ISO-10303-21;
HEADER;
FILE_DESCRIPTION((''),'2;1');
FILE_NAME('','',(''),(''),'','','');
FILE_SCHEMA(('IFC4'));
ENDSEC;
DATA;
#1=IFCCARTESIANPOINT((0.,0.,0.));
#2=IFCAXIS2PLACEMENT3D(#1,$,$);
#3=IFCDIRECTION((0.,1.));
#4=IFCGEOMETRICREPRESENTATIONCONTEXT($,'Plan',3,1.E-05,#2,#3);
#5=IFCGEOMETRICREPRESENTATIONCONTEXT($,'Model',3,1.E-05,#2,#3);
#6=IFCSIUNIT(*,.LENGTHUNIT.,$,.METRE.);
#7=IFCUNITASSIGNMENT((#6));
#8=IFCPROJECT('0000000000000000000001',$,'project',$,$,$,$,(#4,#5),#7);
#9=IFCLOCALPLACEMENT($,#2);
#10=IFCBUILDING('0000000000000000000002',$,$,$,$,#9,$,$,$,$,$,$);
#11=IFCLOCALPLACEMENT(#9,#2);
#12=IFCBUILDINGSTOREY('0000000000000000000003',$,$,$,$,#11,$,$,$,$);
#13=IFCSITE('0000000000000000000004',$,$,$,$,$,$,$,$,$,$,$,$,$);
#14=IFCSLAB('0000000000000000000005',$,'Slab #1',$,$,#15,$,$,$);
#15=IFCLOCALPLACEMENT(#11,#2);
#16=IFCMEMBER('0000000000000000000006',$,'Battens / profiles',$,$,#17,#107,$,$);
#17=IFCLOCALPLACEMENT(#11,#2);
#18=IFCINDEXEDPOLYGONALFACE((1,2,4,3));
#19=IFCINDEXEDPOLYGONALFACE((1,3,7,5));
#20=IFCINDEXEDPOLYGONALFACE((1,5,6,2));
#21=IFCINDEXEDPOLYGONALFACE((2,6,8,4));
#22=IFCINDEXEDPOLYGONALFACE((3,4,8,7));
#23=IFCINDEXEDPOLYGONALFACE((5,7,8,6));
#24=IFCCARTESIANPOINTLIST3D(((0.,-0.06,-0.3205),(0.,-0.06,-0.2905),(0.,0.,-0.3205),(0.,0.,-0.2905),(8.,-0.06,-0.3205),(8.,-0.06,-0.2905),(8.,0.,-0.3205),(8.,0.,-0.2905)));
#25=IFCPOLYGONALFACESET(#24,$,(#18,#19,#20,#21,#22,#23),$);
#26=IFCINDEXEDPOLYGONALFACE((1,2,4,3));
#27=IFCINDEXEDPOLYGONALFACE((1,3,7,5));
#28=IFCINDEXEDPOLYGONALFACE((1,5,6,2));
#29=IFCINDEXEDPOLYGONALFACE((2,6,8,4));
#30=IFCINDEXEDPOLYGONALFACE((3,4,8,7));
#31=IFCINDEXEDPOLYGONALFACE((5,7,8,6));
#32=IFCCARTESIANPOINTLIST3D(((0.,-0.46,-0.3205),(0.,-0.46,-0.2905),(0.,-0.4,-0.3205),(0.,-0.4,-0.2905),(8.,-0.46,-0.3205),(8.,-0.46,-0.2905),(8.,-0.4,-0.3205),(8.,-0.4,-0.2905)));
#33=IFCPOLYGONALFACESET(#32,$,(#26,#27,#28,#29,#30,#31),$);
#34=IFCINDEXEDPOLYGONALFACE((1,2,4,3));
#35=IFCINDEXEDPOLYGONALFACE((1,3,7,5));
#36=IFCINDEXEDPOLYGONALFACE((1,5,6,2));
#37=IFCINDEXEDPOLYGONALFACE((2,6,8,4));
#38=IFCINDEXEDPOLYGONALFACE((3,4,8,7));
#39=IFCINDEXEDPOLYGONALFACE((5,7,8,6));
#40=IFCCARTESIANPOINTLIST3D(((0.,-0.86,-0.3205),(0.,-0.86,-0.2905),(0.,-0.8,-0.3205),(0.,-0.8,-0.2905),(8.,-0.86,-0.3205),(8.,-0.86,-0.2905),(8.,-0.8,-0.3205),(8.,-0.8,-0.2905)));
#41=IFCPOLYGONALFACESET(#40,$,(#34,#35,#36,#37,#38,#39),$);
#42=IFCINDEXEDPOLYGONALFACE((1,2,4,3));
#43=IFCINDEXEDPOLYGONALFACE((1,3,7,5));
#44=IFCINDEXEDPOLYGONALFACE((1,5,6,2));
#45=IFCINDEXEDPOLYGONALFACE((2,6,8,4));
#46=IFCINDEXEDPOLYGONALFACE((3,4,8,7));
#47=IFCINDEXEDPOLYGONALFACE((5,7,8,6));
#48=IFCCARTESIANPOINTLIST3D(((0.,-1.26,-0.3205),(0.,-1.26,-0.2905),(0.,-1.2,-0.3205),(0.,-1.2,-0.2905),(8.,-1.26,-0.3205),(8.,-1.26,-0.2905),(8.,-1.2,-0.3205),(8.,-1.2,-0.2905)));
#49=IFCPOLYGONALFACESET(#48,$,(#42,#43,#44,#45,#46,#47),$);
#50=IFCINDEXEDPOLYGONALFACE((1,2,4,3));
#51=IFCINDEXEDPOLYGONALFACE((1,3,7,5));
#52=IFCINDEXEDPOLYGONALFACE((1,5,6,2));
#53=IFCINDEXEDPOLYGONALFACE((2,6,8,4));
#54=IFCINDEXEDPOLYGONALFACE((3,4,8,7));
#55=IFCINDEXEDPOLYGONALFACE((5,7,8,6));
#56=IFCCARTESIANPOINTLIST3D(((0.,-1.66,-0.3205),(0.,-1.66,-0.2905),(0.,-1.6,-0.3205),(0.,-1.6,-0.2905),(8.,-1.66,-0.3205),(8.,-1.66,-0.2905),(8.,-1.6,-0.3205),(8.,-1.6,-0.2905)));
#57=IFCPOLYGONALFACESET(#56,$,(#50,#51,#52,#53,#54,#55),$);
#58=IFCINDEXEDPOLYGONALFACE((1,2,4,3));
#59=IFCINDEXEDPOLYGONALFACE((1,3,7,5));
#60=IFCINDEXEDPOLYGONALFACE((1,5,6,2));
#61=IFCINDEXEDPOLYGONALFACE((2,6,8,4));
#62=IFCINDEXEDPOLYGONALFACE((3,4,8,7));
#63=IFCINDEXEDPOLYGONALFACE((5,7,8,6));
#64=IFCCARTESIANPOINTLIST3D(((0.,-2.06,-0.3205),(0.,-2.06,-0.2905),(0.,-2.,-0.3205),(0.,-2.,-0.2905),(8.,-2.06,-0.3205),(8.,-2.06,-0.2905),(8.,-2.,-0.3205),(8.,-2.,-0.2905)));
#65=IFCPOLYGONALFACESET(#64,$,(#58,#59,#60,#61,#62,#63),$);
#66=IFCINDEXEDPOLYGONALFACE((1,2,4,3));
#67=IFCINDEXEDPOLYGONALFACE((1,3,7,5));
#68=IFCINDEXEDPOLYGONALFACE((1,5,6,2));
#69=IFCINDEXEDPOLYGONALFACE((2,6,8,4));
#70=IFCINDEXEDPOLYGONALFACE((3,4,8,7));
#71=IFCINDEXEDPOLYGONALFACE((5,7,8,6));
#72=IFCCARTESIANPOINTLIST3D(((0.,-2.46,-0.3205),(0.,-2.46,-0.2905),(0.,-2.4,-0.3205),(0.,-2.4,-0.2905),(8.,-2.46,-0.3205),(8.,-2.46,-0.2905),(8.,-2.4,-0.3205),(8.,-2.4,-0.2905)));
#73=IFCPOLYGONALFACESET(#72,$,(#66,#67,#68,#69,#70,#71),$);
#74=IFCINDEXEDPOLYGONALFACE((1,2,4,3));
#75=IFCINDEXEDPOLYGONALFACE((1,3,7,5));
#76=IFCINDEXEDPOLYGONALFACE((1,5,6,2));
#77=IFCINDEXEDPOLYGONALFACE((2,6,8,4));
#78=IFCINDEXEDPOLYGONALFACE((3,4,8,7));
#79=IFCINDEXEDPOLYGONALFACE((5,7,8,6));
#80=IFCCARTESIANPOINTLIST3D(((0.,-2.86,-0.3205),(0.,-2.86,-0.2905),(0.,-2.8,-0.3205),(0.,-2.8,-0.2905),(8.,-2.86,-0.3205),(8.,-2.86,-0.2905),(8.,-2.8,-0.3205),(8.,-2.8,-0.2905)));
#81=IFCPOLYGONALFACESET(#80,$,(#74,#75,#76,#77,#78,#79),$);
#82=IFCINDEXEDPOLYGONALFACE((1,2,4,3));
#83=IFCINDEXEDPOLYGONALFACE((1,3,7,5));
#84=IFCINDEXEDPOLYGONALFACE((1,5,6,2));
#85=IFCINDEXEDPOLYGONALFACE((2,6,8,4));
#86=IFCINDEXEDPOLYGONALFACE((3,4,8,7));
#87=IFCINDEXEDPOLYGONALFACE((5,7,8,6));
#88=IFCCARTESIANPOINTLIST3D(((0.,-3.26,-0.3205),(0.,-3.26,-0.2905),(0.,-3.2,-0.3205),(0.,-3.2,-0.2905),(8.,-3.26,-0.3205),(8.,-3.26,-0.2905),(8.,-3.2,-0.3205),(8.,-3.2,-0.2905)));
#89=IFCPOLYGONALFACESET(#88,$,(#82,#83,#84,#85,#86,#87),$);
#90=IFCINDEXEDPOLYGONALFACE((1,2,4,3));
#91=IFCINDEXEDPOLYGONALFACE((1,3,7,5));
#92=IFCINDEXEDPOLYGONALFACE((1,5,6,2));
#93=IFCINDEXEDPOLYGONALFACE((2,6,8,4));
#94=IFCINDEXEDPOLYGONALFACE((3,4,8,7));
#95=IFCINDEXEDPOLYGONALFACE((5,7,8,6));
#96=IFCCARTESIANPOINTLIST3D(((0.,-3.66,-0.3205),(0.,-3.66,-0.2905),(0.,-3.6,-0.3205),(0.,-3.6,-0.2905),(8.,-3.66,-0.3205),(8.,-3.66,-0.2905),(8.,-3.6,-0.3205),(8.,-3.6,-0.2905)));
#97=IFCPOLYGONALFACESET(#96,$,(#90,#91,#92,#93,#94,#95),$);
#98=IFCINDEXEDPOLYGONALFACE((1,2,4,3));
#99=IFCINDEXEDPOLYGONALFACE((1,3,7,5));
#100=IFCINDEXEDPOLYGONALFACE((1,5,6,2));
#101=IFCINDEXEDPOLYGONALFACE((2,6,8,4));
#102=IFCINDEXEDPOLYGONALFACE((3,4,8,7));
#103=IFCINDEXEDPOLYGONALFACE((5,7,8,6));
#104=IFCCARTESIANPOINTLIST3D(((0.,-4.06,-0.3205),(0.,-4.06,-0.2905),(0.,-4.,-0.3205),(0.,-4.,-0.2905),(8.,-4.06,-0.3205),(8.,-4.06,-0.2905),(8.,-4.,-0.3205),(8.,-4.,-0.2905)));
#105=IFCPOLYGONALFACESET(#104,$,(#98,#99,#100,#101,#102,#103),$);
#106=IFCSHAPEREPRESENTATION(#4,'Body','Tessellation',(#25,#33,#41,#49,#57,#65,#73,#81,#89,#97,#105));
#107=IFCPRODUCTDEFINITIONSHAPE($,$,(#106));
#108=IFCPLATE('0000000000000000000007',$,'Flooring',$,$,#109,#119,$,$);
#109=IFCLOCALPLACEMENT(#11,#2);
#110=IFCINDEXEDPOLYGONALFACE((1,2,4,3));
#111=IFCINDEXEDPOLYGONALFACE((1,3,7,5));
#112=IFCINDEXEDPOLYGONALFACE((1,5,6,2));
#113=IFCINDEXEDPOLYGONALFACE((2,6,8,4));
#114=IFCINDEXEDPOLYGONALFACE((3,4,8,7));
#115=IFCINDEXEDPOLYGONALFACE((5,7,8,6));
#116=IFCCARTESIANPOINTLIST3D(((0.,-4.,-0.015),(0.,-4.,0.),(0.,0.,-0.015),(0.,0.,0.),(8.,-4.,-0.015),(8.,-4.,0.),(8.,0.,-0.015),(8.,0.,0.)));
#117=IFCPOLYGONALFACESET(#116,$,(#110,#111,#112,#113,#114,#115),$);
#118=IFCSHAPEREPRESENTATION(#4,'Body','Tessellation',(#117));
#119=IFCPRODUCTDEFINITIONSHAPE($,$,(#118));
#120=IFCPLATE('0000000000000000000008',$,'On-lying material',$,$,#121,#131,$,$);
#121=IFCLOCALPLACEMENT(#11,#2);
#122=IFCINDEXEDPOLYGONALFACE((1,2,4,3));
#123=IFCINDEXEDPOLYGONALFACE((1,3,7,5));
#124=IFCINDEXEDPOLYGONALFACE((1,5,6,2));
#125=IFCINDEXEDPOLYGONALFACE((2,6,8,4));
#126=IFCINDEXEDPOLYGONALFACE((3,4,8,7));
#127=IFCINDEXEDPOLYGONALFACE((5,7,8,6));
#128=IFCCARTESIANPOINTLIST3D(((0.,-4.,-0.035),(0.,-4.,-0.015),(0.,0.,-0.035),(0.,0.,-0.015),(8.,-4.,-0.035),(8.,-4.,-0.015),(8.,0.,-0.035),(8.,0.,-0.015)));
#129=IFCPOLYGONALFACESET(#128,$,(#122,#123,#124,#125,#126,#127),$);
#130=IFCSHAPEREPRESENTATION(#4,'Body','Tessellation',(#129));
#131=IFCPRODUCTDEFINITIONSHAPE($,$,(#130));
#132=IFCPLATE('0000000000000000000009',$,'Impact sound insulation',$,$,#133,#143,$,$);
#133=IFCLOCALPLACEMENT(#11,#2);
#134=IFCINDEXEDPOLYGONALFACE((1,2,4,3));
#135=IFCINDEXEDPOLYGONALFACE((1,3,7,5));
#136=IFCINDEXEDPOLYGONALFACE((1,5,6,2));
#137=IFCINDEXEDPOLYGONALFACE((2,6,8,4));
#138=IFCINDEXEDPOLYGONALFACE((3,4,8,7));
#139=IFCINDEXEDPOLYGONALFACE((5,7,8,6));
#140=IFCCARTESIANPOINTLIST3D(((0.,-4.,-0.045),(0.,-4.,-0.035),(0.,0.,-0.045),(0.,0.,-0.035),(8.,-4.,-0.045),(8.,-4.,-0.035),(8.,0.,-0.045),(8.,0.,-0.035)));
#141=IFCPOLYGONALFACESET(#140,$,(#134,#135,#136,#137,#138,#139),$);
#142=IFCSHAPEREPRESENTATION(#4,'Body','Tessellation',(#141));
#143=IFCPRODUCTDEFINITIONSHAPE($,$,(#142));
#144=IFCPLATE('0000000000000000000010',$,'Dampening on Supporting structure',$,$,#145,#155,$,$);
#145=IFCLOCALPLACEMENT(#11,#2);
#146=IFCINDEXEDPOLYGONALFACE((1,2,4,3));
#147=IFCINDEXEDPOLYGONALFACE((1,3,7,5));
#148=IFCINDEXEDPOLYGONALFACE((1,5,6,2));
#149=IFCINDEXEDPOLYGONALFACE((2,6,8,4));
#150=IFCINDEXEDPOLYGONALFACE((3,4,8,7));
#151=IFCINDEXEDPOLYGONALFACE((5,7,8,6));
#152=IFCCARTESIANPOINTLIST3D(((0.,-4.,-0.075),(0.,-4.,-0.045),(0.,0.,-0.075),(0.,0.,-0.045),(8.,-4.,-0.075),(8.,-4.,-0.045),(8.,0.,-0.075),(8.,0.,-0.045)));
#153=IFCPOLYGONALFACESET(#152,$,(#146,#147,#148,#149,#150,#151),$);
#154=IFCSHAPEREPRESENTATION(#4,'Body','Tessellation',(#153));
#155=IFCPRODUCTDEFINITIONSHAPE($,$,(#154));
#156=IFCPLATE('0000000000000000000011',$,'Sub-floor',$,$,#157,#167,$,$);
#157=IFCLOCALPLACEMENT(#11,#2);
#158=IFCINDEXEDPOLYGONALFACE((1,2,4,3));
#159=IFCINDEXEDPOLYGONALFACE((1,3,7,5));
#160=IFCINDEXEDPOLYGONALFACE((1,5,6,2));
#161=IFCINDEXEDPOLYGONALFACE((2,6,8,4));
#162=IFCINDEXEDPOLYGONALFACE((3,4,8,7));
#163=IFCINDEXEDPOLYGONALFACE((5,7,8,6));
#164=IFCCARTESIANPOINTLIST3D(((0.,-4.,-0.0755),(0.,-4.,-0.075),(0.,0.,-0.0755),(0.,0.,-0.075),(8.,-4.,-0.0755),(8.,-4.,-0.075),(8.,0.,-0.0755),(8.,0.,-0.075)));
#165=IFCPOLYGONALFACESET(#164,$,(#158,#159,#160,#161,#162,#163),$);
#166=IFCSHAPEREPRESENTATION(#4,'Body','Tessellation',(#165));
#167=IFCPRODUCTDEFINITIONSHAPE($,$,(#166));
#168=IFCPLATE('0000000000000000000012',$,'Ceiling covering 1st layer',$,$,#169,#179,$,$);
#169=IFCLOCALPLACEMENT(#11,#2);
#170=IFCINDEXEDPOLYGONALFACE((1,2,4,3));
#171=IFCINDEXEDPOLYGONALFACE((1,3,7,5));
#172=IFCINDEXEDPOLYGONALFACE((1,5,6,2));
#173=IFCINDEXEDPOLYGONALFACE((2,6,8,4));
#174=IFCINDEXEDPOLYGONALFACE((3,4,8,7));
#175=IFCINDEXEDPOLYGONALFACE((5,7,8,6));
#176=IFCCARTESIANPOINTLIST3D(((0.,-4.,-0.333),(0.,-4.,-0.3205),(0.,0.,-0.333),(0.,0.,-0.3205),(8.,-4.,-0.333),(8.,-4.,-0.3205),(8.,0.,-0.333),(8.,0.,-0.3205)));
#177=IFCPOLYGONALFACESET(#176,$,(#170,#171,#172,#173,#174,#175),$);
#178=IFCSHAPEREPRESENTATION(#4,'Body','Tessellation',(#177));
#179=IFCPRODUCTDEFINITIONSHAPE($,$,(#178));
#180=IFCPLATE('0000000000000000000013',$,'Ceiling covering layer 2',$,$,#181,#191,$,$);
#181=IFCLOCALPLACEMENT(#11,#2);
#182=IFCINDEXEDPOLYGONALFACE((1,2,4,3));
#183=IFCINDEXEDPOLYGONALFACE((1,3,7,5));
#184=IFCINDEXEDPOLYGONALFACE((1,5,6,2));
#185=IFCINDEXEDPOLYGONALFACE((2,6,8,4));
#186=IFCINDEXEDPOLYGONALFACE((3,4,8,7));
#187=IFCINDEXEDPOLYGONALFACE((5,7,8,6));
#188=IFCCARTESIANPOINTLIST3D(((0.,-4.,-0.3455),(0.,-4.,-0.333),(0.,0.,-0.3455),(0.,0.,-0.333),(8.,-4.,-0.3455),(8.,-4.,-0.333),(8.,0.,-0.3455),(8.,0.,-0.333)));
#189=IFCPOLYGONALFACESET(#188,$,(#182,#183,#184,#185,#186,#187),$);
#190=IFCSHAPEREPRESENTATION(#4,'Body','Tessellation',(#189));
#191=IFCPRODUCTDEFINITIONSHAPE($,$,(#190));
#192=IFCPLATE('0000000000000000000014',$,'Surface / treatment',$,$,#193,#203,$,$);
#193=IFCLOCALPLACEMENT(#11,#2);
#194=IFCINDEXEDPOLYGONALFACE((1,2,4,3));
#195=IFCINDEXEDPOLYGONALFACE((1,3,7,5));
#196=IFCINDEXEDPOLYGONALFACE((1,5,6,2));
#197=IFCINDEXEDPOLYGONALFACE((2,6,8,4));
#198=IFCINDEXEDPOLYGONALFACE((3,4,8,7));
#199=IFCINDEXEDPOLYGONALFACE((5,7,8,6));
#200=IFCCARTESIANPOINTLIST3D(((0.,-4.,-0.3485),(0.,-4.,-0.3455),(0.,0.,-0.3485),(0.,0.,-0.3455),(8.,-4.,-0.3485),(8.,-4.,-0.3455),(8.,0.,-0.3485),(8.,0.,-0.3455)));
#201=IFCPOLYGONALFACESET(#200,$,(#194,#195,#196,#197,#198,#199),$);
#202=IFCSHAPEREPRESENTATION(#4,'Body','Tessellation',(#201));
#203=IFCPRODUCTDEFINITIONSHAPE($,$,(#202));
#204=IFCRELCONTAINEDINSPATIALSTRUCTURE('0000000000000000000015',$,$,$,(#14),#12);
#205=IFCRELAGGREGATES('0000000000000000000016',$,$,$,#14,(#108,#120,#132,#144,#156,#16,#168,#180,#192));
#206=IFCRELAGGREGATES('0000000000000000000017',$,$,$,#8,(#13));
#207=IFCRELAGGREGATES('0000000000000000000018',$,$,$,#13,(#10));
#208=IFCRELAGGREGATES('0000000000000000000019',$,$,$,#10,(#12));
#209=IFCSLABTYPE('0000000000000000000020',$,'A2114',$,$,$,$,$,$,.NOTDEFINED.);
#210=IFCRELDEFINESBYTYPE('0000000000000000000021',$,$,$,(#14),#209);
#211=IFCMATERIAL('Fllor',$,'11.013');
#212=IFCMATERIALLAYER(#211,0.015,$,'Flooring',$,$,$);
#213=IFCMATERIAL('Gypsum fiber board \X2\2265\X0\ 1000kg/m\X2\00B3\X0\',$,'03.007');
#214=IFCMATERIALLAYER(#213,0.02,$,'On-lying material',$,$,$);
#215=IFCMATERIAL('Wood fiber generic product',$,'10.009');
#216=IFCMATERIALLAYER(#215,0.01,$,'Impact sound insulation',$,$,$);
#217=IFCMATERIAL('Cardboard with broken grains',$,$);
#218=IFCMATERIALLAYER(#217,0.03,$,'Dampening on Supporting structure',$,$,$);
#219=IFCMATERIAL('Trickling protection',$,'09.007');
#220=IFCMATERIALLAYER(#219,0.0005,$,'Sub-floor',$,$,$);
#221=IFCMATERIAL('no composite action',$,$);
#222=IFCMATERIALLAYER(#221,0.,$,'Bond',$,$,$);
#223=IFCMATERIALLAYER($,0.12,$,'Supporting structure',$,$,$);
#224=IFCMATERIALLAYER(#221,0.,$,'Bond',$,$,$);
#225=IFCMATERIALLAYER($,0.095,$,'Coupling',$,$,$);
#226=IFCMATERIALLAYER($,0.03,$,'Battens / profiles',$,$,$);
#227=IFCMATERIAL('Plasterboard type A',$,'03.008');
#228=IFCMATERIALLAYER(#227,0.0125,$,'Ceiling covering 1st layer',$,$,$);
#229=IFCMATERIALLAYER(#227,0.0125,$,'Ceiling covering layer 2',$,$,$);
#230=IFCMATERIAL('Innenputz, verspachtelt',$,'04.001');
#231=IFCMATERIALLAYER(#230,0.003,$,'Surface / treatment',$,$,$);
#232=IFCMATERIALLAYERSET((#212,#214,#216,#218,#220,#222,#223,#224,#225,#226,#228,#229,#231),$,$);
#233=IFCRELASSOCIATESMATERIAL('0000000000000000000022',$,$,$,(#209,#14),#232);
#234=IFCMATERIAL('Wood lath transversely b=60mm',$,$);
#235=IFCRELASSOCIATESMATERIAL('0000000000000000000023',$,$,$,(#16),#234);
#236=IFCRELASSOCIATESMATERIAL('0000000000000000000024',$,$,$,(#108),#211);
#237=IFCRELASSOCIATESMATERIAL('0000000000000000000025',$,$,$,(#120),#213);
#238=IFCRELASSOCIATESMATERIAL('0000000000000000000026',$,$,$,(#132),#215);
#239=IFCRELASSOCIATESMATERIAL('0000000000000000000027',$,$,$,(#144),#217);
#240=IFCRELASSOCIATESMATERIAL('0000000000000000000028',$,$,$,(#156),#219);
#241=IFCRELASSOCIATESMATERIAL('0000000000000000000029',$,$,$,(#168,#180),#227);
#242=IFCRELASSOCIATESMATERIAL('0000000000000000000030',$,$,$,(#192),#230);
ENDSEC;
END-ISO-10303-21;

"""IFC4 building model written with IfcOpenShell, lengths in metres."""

from ifc_helpers import new_model, si_unit, direction, frame, frame_2d, origin, origin_with_axes, place, context, project, spatial, rectangle, extrude, material, layer, layer_set, type_object, element, aggregate, save


model = new_model("IFC4")

# Units and contexts
plan_context = context("Plan", 3, precision=1e-05, world=origin(), true_north=direction((0.0, 1.0)))
model_context = context("Model", 3, precision=1e-05, world=origin(), true_north=direction((0.0, 1.0)))
ifc_project = project(units=[si_unit("LENGTHUNIT", "METRE")], contexts=[plan_context, model_context])

# Site, building, storey
site = spatial("IfcSite", under=ifc_project)
building_placement = place(None, origin())
building = spatial("IfcBuilding", under=site, at=building_placement)
storey_placement = place(building_placement, origin())
storey = spatial("IfcBuildingStorey", under=building, at=storey_placement)

# Slab, member, plates
ifc_material_1 = material(Name="Fllor", Category="11.013")
ifc_layer_1 = layer(ifc_material_1, 0.015, Name="Flooring")
ifc_material_2 = material(Name="Gypsum fiber board ≥ 1000kg/m³", Category="03.007")
ifc_layer_2 = layer(ifc_material_2, 0.02, Name="On-lying material")
ifc_material_3 = material(Name="Wood fiber generic product", Category="10.009")
ifc_layer_3 = layer(ifc_material_3, 0.01, Name="Impact sound insulation")
ifc_material_4 = material(Name="Cardboard with broken grains")
ifc_layer_4 = layer(ifc_material_4, 0.03, Name="Dampening on Supporting structure")
ifc_material_5 = material(Name="Trickling protection", Category="09.007")
ifc_layer_5 = layer(ifc_material_5, 0.0005, Name="Sub-floor")
ifc_material_6 = material(Name="no composite action")
ifc_layer_6 = layer(ifc_material_6, 0.0, Name="Bond")
ifc_layer_7 = layer(None, 0.12, Name="Supporting structure")
ifc_layer_8 = layer(ifc_material_6, 0.0, Name="Bond")
ifc_layer_9 = layer(None, 0.095, Name="Coupling")
ifc_layer_10 = layer(None, 0.03, Name="Battens / profiles")
ifc_material_7 = material(Name="Plasterboard type A", Category="03.008")
ifc_layer_11 = layer(ifc_material_7, 0.0125, Name="Ceiling covering 1st layer")
ifc_layer_12 = layer(ifc_material_7, 0.0125, Name="Ceiling covering layer 2")
ifc_material_8 = material(Name="Innenputz, verspachtelt", Category="04.001")
ifc_layer_13 = layer(ifc_material_8, 0.003, Name="Surface / treatment")
ifc_layer_set = layer_set([ifc_layer_1, ifc_layer_2, ifc_layer_3, ifc_layer_4, ifc_layer_5, ifc_layer_6, ifc_layer_7, ifc_layer_8, ifc_layer_9, ifc_layer_10, ifc_layer_11, ifc_layer_12, ifc_layer_13])
slab_type = type_object("IfcSlabType", Name="A2114", PredefinedType="NOTDEFINED", material=ifc_layer_set)
slab_placement = place(None, frame((0.0, 0.0, 0.0), z_axis=(0.0, 0.0, -1.0), x_axis=(1.0, 0.0, 0.0)))
slab = element("IfcSlab", 1, at=slab_placement, inside=storey, type_object=slab_type, material=ifc_layer_set, Name="Slab #1")
ifc_material_9 = material(Name="Wood lath transversely b=60mm")
member_1_placement = place(slab_placement, origin())
member_1 = element("IfcMember", 2, at=member_1_placement, material=ifc_material_9, Name="Battens / profiles", context=plan_context, shape_type="SweptSolid", body=[
    extrude(rectangle(XDim=0.06, YDim=0.03, at=frame_2d((0.03, 0.015), x_axis=(1.0, 0.0))), frame((0.0, 0.0, 0.2905), z_axis=(1.0, 0.0, 0.0), x_axis=(0.0, 1.0, 0.0)), (0.0, 0.0, 1.0), 8.0),
    extrude(rectangle(XDim=0.06, YDim=0.03, at=frame_2d((0.03, 0.015), x_axis=(1.0, 0.0))), frame((0.0, 0.4, 0.2905), z_axis=(1.0, 0.0, 0.0), x_axis=(0.0, 1.0, 0.0)), (0.0, 0.0, 1.0), 8.0),
    extrude(rectangle(XDim=0.06, YDim=0.03, at=frame_2d((0.03, 0.015), x_axis=(1.0, 0.0))), frame((0.0, 0.8, 0.2905), z_axis=(1.0, 0.0, 0.0), x_axis=(0.0, 1.0, 0.0)), (0.0, 0.0, 1.0), 8.0),
    extrude(rectangle(XDim=0.06, YDim=0.03, at=frame_2d((0.03, 0.015), x_axis=(1.0, 0.0))), frame((0.0, 1.2, 0.2905), z_axis=(1.0, 0.0, 0.0), x_axis=(0.0, 1.0, 0.0)), (0.0, 0.0, 1.0), 8.0),
    extrude(rectangle(XDim=0.06, YDim=0.03, at=frame_2d((0.03, 0.015), x_axis=(1.0, 0.0))), frame((0.0, 1.6, 0.2905), z_axis=(1.0, 0.0, 0.0), x_axis=(0.0, 1.0, 0.0)), (0.0, 0.0, 1.0), 8.0),
    extrude(rectangle(XDim=0.06, YDim=0.03, at=frame_2d((0.03, 0.015), x_axis=(1.0, 0.0))), frame((0.0, 2.0, 0.2905), z_axis=(1.0, 0.0, 0.0), x_axis=(0.0, 1.0, 0.0)), (0.0, 0.0, 1.0), 8.0),
    extrude(rectangle(XDim=0.06, YDim=0.03, at=frame_2d((0.03, 0.015), x_axis=(1.0, 0.0))), frame((0.0, 2.4, 0.2905), z_axis=(1.0, 0.0, 0.0), x_axis=(0.0, 1.0, 0.0)), (0.0, 0.0, 1.0), 8.0),
    extrude(rectangle(XDim=0.06, YDim=0.03, at=frame_2d((0.03, 0.015), x_axis=(1.0, 0.0))), frame((0.0, 2.8, 0.2905), z_axis=(1.0, 0.0, 0.0), x_axis=(0.0, 1.0, 0.0)), (0.0, 0.0, 1.0), 8.0),
    extrude(rectangle(XDim=0.06, YDim=0.03, at=frame_2d((0.03, 0.015), x_axis=(1.0, 0.0))), frame((0.0, 3.2, 0.2905), z_axis=(1.0, 0.0, 0.0), x_axis=(0.0, 1.0, 0.0)), (0.0, 0.0, 1.0), 8.0),
    extrude(rectangle(XDim=0.06, YDim=0.03, at=frame_2d((0.03, 0.015), x_axis=(1.0, 0.0))), frame((0.0, 3.6, 0.2905), z_axis=(1.0, 0.0, 0.0), x_axis=(0.0, 1.0, 0.0)), (0.0, 0.0, 1.0), 8.0),
    extrude(rectangle(XDim=0.06, YDim=0.03, at=frame_2d((0.03, 0.015), x_axis=(1.0, 0.0))), frame((0.0, 4.0, 0.2905), z_axis=(1.0, 0.0, 0.0), x_axis=(0.0, 1.0, 0.0)), (0.0, 0.0, 1.0), 8.0),
])
plate_1_placement = place(slab_placement, origin())
plate_1 = element("IfcPlate", 3, at=plate_1_placement, material=ifc_material_1, Name="Flooring", context=plan_context, shape_type="SweptSolid", body=[
    extrude(rectangle(XDim=8.0, YDim=4.0, at=frame_2d((4.0, 2.0), x_axis=(1.0, 0.0))), origin_with_axes(), (0.0, 0.0, 1.0), 0.015),
])
plate_2_placement = place(slab_placement, origin())
plate_2 = element("IfcPlate", 4, at=plate_2_placement, material=ifc_material_2, Name="On-lying material", context=plan_context, shape_type="SweptSolid", body=[
    extrude(rectangle(XDim=8.0, YDim=4.0, at=frame_2d((4.0, 2.0), x_axis=(1.0, 0.0))), frame((0.0, 0.0, 0.015), z_axis=(0.0, 0.0, 1.0), x_axis=(1.0, 0.0, 0.0)), (0.0, 0.0, 1.0), 0.02),
])
plate_3_placement = place(slab_placement, origin())
plate_3 = element("IfcPlate", 5, at=plate_3_placement, material=ifc_material_3, Name="Impact sound insulation", context=plan_context, shape_type="SweptSolid", body=[
    extrude(rectangle(XDim=8.0, YDim=4.0, at=frame_2d((4.0, 2.0), x_axis=(1.0, 0.0))), frame((0.0, 0.0, 0.035), z_axis=(0.0, 0.0, 1.0), x_axis=(1.0, 0.0, 0.0)), (0.0, 0.0, 1.0), 0.01),
])
plate_4_placement = place(slab_placement, origin())
plate_4 = element("IfcPlate", 6, at=plate_4_placement, material=ifc_material_4, Name="Dampening on Supporting structure", context=plan_context, shape_type="SweptSolid", body=[
    extrude(rectangle(XDim=8.0, YDim=4.0, at=frame_2d((4.0, 2.0), x_axis=(1.0, 0.0))), frame((0.0, 0.0, 0.045), z_axis=(0.0, 0.0, 1.0), x_axis=(1.0, 0.0, 0.0)), (0.0, 0.0, 1.0), 0.03),
])
plate_5_placement = place(slab_placement, origin())
plate_5 = element("IfcPlate", 7, at=plate_5_placement, material=ifc_material_5, Name="Sub-floor", context=plan_context, shape_type="SweptSolid", body=[
    extrude(rectangle(XDim=8.0, YDim=4.0, at=frame_2d((4.0, 2.0), x_axis=(1.0, 0.0))), frame((0.0, 0.0, 0.075), z_axis=(0.0, 0.0, 1.0), x_axis=(1.0, 0.0, 0.0)), (0.0, 0.0, 1.0), 0.0005),
])
plate_6_placement = place(slab_placement, origin())
plate_6 = element("IfcPlate", 8, at=plate_6_placement, material=ifc_material_7, Name="Ceiling covering 1st layer", context=plan_context, shape_type="SweptSolid", body=[
    extrude(rectangle(XDim=8.0, YDim=4.0, at=frame_2d((4.0, 2.0), x_axis=(1.0, 0.0))), frame((0.0, 0.0, 0.3205), z_axis=(0.0, 0.0, 1.0), x_axis=(1.0, 0.0, 0.0)), (0.0, 0.0, 1.0), 0.0125),
])
plate_7_placement = place(slab_placement, origin())
plate_7 = element("IfcPlate", 9, at=plate_7_placement, material=ifc_material_7, Name="Ceiling covering layer 2", context=plan_context, shape_type="SweptSolid", body=[
    extrude(rectangle(XDim=8.0, YDim=4.0, at=frame_2d((4.0, 2.0), x_axis=(1.0, 0.0))), frame((0.0, 0.0, 0.333), z_axis=(0.0, 0.0, 1.0), x_axis=(1.0, 0.0, 0.0)), (0.0, 0.0, 1.0), 0.0125),
])
plate_8_placement = place(slab_placement, origin())
plate_8 = element("IfcPlate", 10, at=plate_8_placement, material=ifc_material_8, Name="Surface / treatment", context=plan_context, shape_type="SweptSolid", body=[
    extrude(rectangle(XDim=8.0, YDim=4.0, at=frame_2d((4.0, 2.0), x_axis=(1.0, 0.0))), frame((0.0, 0.0, 0.3455), z_axis=(0.0, 0.0, 1.0), x_axis=(1.0, 0.0, 0.0)), (0.0, 0.0, 1.0), 0.003),
])
aggregate(slab, [plate_1, plate_2, plate_3, plate_4, plate_5, member_1, plate_6, plate_7, plate_8])

save(model, "model.ifc")
